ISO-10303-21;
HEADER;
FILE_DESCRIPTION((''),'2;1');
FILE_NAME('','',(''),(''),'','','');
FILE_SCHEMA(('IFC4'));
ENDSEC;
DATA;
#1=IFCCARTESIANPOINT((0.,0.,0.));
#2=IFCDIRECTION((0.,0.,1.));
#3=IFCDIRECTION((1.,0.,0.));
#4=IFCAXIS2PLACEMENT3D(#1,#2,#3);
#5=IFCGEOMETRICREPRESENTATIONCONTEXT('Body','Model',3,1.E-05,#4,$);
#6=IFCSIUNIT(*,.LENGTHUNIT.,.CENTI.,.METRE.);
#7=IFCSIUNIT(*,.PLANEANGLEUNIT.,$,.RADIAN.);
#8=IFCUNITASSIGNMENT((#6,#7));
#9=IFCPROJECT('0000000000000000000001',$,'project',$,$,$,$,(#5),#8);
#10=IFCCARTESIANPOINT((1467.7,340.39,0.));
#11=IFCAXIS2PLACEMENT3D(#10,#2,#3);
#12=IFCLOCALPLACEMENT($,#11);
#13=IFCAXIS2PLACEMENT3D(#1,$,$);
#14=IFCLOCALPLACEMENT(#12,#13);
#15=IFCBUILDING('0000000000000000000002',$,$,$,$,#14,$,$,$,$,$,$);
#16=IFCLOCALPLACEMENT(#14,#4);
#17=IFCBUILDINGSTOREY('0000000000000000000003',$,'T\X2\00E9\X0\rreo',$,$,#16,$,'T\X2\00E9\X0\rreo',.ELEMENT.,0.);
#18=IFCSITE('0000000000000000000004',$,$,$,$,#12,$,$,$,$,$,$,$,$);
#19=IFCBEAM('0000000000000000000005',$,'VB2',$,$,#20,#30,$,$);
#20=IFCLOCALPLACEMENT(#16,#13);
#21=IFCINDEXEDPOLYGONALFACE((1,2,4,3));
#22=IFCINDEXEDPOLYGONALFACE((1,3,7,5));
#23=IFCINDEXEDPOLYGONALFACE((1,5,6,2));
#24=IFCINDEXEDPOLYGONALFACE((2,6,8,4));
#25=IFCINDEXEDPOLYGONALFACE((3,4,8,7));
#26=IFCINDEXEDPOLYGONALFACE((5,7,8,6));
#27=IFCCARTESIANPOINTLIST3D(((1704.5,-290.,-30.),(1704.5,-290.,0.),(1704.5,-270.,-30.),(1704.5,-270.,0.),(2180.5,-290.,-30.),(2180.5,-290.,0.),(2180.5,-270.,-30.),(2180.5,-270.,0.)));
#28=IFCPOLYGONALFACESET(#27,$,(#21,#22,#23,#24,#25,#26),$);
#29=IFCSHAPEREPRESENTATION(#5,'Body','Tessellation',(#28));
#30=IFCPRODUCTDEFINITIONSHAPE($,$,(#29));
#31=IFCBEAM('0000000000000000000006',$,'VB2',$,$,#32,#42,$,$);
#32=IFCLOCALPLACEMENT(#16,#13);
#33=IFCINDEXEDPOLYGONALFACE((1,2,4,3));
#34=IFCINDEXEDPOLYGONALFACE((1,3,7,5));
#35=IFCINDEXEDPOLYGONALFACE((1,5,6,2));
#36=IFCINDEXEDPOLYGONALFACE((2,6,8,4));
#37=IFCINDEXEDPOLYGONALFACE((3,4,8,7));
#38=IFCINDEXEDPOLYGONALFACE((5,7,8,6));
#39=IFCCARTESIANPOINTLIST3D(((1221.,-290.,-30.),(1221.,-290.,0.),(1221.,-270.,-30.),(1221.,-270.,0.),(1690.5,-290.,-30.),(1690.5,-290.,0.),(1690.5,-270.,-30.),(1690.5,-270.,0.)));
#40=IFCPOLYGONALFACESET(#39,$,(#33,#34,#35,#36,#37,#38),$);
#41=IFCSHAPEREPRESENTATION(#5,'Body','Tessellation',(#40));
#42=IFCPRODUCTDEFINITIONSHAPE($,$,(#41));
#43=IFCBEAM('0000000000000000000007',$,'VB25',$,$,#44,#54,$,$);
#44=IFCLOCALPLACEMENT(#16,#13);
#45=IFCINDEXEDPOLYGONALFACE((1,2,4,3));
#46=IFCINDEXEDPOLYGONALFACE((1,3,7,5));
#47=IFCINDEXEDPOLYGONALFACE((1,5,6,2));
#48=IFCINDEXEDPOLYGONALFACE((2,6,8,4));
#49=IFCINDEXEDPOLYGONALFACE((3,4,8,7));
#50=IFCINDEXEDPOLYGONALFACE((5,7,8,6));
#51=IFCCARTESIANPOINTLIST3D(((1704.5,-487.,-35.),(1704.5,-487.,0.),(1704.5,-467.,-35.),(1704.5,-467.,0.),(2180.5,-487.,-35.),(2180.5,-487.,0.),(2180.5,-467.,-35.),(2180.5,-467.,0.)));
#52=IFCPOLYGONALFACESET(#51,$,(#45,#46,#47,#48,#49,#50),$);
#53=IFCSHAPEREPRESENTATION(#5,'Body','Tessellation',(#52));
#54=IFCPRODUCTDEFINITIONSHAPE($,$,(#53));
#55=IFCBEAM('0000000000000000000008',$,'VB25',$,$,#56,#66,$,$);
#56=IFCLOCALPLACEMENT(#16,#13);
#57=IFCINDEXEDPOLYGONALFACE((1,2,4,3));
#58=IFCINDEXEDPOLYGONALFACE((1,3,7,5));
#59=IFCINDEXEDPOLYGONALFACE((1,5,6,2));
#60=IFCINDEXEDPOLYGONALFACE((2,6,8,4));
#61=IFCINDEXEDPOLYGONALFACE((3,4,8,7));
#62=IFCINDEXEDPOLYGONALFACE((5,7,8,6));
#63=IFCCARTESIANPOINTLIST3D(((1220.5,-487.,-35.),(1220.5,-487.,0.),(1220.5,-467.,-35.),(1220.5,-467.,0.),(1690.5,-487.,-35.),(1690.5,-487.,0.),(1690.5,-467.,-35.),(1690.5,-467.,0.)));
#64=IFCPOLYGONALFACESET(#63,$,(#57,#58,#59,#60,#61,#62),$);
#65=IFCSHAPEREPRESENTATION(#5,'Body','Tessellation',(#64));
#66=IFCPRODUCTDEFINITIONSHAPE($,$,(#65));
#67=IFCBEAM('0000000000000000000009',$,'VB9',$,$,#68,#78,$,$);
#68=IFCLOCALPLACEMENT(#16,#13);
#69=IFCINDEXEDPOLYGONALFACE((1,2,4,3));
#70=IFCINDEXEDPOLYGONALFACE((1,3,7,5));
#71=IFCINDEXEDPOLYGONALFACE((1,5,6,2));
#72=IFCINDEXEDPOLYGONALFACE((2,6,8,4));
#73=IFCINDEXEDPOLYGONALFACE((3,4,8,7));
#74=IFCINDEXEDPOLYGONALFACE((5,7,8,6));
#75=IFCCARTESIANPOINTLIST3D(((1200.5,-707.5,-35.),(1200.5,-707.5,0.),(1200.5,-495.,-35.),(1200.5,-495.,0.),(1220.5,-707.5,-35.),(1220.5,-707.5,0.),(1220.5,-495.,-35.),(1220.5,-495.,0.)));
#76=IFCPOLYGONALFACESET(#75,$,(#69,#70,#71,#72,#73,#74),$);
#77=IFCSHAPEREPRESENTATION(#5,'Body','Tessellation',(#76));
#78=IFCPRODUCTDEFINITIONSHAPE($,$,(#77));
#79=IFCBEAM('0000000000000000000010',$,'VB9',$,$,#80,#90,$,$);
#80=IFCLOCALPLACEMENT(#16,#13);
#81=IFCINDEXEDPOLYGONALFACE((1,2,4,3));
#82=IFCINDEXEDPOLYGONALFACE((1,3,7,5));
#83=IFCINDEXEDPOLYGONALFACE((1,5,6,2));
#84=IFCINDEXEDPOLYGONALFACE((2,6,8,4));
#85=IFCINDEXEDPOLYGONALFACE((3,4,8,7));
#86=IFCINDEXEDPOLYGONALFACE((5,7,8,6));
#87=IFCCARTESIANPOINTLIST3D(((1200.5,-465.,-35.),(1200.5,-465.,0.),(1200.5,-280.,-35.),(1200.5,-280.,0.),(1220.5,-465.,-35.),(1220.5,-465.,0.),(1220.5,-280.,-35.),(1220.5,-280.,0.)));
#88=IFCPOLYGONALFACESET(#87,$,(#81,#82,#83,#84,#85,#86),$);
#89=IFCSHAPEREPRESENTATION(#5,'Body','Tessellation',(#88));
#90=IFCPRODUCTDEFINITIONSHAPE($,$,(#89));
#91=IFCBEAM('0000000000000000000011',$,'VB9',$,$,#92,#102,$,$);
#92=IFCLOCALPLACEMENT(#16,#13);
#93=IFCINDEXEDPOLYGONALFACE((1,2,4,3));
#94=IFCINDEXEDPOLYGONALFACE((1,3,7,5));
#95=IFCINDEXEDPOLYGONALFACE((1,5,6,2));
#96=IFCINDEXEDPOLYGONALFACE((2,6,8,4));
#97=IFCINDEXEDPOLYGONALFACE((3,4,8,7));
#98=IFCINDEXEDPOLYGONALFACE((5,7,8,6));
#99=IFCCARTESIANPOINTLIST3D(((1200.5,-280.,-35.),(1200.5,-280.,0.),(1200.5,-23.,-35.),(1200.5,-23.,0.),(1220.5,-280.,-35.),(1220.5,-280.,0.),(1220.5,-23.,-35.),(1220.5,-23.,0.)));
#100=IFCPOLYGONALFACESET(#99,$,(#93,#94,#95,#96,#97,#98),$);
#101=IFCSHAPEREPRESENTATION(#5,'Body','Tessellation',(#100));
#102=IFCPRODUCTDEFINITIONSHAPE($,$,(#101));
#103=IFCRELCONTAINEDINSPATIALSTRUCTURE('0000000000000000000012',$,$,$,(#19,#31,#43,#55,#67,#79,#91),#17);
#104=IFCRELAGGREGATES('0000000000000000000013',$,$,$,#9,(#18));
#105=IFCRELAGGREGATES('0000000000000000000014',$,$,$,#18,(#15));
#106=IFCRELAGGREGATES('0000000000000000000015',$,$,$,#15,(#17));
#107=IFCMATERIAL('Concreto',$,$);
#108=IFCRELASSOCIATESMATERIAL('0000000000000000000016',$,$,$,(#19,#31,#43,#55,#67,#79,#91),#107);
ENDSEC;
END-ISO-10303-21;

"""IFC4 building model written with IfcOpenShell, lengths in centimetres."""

from ifc_helpers import new_model, si_unit, frame, origin, origin_with_axes, origin_2d_with_axis, place, context, project, spatial, rectangle, extrude, material, element, save


model = new_model("IFC4")

# Units and contexts
model_context = context("Model", 3, precision=1e-05, world=origin_with_axes(), identifier="Body")
ifc_project = project(units=[si_unit("LENGTHUNIT", "METRE", prefix="CENTI"), si_unit("PLANEANGLEUNIT", "RADIAN")], contexts=[model_context])

# Site, building, storey
site_placement = place(None, frame((1467.7, 340.39, 0.0), z_axis=(0.0, 0.0, 1.0), x_axis=(1.0, 0.0, 0.0)))
site = spatial("IfcSite", under=ifc_project, at=site_placement)
building_placement = place(site_placement, origin())
building = spatial("IfcBuilding", under=site, at=building_placement)
storey_placement = place(building_placement, origin_with_axes())
storey = spatial("IfcBuildingStorey", under=building, at=storey_placement, Name="Térreo", LongName="Térreo", CompositionType="ELEMENT", Elevation=0.0)

# Shared definitions
ifc_material = material(Name="Concreto")

# Beams
beam_1_placement = place(storey_placement, frame((1942.5, -280.0, 0.0), z_axis=(0.0, 0.0, 1.0), x_axis=(1.0, 0.0, 0.0)))
element("IfcBeam", 1, at=beam_1_placement, inside=storey, material=ifc_material, Name="VB2", context=model_context, shape_type="SolidModel", body=[
    extrude(rectangle(XDim=20.0, YDim=30.0, at=origin_2d_with_axis()), frame((-238.0, 0.0, -15.0), z_axis=(1.0, 0.0, 0.0), x_axis=(0.0, 1.0, 0.0)), (0.0, 0.0, 1.0), 476.0),
])
beam_2_placement = place(storey_placement, frame((1455.75, -280.0, 0.0), z_axis=(0.0, 0.0, 1.0), x_axis=(1.0, 0.0, 0.0)))
element("IfcBeam", 2, at=beam_2_placement, inside=storey, material=ifc_material, Name="VB2", context=model_context, shape_type="SolidModel", body=[
    extrude(rectangle(XDim=20.0, YDim=30.0, at=origin_2d_with_axis()), frame((-234.75, 0.0, -15.0), z_axis=(1.0, 0.0, 0.0), x_axis=(0.0, 1.0, 0.0)), (0.0, 0.0, 1.0), 469.5),
])
beam_3_placement = place(storey_placement, frame((1942.5, -477.0, 0.0), z_axis=(0.0, 0.0, 1.0), x_axis=(1.0, 0.0, 0.0)))
element("IfcBeam", 3, at=beam_3_placement, inside=storey, material=ifc_material, Name="VB25", context=model_context, shape_type="SolidModel", body=[
    extrude(rectangle(XDim=20.0, YDim=35.0, at=origin_2d_with_axis()), frame((-238.0, 0.0, -17.5), z_axis=(1.0, 0.0, 0.0), x_axis=(0.0, 1.0, 0.0)), (0.0, 0.0, 1.0), 476.0),
])
beam_4_placement = place(storey_placement, frame((1455.5, -477.0, 0.0), z_axis=(0.0, 0.0, 1.0), x_axis=(1.0, 0.0, 0.0)))
element("IfcBeam", 4, at=beam_4_placement, inside=storey, material=ifc_material, Name="VB25", context=model_context, shape_type="SolidModel", body=[
    extrude(rectangle(XDim=20.0, YDim=35.0, at=origin_2d_with_axis()), frame((-235.0, 0.0, -17.5), z_axis=(1.0, 0.0, 0.0), x_axis=(0.0, 1.0, 0.0)), (0.0, 0.0, 1.0), 470.0),
])
beam_5_placement = place(storey_placement, frame((1210.5, -601.25, 0.0), z_axis=(0.0, 0.0, 1.0), x_axis=(1.0, 0.0, 0.0)))
element("IfcBeam", 5, at=beam_5_placement, inside=storey, material=ifc_material, Name="VB9", context=model_context, shape_type="SolidModel", body=[
    extrude(rectangle(XDim=20.0, YDim=35.0, at=origin_2d_with_axis()), frame((0.0, -106.25, -17.5), z_axis=(0.0, 1.0, 0.0), x_axis=(1.0, 0.0, 0.0)), (0.0, 0.0, 1.0), 212.5),
])
beam_6_placement = place(storey_placement, frame((1210.5, -372.5, 0.0), z_axis=(0.0, 0.0, 1.0), x_axis=(1.0, 0.0, 0.0)))
element("IfcBeam", 6, at=beam_6_placement, inside=storey, material=ifc_material, Name="VB9", context=model_context, shape_type="SolidModel", body=[
    extrude(rectangle(XDim=20.0, YDim=35.0, at=origin_2d_with_axis()), frame((0.0, -92.5, -17.5), z_axis=(0.0, 1.0, 0.0), x_axis=(1.0, 0.0, 0.0)), (0.0, 0.0, 1.0), 185.0),
])
beam_7_placement = place(storey_placement, frame((1210.5, -151.5, 0.0), z_axis=(0.0, 0.0, 1.0), x_axis=(1.0, 0.0, 0.0)))
element("IfcBeam", 7, at=beam_7_placement, inside=storey, material=ifc_material, Name="VB9", context=model_context, shape_type="SolidModel", body=[
    extrude(rectangle(XDim=20.0, YDim=35.0, at=origin_2d_with_axis()), frame((0.0, -128.5, -17.5), z_axis=(0.0, 1.0, 0.0), x_axis=(1.0, 0.0, 0.0)), (0.0, 0.0, 1.0), 257.0),
])

save(model, "model.ifc")
